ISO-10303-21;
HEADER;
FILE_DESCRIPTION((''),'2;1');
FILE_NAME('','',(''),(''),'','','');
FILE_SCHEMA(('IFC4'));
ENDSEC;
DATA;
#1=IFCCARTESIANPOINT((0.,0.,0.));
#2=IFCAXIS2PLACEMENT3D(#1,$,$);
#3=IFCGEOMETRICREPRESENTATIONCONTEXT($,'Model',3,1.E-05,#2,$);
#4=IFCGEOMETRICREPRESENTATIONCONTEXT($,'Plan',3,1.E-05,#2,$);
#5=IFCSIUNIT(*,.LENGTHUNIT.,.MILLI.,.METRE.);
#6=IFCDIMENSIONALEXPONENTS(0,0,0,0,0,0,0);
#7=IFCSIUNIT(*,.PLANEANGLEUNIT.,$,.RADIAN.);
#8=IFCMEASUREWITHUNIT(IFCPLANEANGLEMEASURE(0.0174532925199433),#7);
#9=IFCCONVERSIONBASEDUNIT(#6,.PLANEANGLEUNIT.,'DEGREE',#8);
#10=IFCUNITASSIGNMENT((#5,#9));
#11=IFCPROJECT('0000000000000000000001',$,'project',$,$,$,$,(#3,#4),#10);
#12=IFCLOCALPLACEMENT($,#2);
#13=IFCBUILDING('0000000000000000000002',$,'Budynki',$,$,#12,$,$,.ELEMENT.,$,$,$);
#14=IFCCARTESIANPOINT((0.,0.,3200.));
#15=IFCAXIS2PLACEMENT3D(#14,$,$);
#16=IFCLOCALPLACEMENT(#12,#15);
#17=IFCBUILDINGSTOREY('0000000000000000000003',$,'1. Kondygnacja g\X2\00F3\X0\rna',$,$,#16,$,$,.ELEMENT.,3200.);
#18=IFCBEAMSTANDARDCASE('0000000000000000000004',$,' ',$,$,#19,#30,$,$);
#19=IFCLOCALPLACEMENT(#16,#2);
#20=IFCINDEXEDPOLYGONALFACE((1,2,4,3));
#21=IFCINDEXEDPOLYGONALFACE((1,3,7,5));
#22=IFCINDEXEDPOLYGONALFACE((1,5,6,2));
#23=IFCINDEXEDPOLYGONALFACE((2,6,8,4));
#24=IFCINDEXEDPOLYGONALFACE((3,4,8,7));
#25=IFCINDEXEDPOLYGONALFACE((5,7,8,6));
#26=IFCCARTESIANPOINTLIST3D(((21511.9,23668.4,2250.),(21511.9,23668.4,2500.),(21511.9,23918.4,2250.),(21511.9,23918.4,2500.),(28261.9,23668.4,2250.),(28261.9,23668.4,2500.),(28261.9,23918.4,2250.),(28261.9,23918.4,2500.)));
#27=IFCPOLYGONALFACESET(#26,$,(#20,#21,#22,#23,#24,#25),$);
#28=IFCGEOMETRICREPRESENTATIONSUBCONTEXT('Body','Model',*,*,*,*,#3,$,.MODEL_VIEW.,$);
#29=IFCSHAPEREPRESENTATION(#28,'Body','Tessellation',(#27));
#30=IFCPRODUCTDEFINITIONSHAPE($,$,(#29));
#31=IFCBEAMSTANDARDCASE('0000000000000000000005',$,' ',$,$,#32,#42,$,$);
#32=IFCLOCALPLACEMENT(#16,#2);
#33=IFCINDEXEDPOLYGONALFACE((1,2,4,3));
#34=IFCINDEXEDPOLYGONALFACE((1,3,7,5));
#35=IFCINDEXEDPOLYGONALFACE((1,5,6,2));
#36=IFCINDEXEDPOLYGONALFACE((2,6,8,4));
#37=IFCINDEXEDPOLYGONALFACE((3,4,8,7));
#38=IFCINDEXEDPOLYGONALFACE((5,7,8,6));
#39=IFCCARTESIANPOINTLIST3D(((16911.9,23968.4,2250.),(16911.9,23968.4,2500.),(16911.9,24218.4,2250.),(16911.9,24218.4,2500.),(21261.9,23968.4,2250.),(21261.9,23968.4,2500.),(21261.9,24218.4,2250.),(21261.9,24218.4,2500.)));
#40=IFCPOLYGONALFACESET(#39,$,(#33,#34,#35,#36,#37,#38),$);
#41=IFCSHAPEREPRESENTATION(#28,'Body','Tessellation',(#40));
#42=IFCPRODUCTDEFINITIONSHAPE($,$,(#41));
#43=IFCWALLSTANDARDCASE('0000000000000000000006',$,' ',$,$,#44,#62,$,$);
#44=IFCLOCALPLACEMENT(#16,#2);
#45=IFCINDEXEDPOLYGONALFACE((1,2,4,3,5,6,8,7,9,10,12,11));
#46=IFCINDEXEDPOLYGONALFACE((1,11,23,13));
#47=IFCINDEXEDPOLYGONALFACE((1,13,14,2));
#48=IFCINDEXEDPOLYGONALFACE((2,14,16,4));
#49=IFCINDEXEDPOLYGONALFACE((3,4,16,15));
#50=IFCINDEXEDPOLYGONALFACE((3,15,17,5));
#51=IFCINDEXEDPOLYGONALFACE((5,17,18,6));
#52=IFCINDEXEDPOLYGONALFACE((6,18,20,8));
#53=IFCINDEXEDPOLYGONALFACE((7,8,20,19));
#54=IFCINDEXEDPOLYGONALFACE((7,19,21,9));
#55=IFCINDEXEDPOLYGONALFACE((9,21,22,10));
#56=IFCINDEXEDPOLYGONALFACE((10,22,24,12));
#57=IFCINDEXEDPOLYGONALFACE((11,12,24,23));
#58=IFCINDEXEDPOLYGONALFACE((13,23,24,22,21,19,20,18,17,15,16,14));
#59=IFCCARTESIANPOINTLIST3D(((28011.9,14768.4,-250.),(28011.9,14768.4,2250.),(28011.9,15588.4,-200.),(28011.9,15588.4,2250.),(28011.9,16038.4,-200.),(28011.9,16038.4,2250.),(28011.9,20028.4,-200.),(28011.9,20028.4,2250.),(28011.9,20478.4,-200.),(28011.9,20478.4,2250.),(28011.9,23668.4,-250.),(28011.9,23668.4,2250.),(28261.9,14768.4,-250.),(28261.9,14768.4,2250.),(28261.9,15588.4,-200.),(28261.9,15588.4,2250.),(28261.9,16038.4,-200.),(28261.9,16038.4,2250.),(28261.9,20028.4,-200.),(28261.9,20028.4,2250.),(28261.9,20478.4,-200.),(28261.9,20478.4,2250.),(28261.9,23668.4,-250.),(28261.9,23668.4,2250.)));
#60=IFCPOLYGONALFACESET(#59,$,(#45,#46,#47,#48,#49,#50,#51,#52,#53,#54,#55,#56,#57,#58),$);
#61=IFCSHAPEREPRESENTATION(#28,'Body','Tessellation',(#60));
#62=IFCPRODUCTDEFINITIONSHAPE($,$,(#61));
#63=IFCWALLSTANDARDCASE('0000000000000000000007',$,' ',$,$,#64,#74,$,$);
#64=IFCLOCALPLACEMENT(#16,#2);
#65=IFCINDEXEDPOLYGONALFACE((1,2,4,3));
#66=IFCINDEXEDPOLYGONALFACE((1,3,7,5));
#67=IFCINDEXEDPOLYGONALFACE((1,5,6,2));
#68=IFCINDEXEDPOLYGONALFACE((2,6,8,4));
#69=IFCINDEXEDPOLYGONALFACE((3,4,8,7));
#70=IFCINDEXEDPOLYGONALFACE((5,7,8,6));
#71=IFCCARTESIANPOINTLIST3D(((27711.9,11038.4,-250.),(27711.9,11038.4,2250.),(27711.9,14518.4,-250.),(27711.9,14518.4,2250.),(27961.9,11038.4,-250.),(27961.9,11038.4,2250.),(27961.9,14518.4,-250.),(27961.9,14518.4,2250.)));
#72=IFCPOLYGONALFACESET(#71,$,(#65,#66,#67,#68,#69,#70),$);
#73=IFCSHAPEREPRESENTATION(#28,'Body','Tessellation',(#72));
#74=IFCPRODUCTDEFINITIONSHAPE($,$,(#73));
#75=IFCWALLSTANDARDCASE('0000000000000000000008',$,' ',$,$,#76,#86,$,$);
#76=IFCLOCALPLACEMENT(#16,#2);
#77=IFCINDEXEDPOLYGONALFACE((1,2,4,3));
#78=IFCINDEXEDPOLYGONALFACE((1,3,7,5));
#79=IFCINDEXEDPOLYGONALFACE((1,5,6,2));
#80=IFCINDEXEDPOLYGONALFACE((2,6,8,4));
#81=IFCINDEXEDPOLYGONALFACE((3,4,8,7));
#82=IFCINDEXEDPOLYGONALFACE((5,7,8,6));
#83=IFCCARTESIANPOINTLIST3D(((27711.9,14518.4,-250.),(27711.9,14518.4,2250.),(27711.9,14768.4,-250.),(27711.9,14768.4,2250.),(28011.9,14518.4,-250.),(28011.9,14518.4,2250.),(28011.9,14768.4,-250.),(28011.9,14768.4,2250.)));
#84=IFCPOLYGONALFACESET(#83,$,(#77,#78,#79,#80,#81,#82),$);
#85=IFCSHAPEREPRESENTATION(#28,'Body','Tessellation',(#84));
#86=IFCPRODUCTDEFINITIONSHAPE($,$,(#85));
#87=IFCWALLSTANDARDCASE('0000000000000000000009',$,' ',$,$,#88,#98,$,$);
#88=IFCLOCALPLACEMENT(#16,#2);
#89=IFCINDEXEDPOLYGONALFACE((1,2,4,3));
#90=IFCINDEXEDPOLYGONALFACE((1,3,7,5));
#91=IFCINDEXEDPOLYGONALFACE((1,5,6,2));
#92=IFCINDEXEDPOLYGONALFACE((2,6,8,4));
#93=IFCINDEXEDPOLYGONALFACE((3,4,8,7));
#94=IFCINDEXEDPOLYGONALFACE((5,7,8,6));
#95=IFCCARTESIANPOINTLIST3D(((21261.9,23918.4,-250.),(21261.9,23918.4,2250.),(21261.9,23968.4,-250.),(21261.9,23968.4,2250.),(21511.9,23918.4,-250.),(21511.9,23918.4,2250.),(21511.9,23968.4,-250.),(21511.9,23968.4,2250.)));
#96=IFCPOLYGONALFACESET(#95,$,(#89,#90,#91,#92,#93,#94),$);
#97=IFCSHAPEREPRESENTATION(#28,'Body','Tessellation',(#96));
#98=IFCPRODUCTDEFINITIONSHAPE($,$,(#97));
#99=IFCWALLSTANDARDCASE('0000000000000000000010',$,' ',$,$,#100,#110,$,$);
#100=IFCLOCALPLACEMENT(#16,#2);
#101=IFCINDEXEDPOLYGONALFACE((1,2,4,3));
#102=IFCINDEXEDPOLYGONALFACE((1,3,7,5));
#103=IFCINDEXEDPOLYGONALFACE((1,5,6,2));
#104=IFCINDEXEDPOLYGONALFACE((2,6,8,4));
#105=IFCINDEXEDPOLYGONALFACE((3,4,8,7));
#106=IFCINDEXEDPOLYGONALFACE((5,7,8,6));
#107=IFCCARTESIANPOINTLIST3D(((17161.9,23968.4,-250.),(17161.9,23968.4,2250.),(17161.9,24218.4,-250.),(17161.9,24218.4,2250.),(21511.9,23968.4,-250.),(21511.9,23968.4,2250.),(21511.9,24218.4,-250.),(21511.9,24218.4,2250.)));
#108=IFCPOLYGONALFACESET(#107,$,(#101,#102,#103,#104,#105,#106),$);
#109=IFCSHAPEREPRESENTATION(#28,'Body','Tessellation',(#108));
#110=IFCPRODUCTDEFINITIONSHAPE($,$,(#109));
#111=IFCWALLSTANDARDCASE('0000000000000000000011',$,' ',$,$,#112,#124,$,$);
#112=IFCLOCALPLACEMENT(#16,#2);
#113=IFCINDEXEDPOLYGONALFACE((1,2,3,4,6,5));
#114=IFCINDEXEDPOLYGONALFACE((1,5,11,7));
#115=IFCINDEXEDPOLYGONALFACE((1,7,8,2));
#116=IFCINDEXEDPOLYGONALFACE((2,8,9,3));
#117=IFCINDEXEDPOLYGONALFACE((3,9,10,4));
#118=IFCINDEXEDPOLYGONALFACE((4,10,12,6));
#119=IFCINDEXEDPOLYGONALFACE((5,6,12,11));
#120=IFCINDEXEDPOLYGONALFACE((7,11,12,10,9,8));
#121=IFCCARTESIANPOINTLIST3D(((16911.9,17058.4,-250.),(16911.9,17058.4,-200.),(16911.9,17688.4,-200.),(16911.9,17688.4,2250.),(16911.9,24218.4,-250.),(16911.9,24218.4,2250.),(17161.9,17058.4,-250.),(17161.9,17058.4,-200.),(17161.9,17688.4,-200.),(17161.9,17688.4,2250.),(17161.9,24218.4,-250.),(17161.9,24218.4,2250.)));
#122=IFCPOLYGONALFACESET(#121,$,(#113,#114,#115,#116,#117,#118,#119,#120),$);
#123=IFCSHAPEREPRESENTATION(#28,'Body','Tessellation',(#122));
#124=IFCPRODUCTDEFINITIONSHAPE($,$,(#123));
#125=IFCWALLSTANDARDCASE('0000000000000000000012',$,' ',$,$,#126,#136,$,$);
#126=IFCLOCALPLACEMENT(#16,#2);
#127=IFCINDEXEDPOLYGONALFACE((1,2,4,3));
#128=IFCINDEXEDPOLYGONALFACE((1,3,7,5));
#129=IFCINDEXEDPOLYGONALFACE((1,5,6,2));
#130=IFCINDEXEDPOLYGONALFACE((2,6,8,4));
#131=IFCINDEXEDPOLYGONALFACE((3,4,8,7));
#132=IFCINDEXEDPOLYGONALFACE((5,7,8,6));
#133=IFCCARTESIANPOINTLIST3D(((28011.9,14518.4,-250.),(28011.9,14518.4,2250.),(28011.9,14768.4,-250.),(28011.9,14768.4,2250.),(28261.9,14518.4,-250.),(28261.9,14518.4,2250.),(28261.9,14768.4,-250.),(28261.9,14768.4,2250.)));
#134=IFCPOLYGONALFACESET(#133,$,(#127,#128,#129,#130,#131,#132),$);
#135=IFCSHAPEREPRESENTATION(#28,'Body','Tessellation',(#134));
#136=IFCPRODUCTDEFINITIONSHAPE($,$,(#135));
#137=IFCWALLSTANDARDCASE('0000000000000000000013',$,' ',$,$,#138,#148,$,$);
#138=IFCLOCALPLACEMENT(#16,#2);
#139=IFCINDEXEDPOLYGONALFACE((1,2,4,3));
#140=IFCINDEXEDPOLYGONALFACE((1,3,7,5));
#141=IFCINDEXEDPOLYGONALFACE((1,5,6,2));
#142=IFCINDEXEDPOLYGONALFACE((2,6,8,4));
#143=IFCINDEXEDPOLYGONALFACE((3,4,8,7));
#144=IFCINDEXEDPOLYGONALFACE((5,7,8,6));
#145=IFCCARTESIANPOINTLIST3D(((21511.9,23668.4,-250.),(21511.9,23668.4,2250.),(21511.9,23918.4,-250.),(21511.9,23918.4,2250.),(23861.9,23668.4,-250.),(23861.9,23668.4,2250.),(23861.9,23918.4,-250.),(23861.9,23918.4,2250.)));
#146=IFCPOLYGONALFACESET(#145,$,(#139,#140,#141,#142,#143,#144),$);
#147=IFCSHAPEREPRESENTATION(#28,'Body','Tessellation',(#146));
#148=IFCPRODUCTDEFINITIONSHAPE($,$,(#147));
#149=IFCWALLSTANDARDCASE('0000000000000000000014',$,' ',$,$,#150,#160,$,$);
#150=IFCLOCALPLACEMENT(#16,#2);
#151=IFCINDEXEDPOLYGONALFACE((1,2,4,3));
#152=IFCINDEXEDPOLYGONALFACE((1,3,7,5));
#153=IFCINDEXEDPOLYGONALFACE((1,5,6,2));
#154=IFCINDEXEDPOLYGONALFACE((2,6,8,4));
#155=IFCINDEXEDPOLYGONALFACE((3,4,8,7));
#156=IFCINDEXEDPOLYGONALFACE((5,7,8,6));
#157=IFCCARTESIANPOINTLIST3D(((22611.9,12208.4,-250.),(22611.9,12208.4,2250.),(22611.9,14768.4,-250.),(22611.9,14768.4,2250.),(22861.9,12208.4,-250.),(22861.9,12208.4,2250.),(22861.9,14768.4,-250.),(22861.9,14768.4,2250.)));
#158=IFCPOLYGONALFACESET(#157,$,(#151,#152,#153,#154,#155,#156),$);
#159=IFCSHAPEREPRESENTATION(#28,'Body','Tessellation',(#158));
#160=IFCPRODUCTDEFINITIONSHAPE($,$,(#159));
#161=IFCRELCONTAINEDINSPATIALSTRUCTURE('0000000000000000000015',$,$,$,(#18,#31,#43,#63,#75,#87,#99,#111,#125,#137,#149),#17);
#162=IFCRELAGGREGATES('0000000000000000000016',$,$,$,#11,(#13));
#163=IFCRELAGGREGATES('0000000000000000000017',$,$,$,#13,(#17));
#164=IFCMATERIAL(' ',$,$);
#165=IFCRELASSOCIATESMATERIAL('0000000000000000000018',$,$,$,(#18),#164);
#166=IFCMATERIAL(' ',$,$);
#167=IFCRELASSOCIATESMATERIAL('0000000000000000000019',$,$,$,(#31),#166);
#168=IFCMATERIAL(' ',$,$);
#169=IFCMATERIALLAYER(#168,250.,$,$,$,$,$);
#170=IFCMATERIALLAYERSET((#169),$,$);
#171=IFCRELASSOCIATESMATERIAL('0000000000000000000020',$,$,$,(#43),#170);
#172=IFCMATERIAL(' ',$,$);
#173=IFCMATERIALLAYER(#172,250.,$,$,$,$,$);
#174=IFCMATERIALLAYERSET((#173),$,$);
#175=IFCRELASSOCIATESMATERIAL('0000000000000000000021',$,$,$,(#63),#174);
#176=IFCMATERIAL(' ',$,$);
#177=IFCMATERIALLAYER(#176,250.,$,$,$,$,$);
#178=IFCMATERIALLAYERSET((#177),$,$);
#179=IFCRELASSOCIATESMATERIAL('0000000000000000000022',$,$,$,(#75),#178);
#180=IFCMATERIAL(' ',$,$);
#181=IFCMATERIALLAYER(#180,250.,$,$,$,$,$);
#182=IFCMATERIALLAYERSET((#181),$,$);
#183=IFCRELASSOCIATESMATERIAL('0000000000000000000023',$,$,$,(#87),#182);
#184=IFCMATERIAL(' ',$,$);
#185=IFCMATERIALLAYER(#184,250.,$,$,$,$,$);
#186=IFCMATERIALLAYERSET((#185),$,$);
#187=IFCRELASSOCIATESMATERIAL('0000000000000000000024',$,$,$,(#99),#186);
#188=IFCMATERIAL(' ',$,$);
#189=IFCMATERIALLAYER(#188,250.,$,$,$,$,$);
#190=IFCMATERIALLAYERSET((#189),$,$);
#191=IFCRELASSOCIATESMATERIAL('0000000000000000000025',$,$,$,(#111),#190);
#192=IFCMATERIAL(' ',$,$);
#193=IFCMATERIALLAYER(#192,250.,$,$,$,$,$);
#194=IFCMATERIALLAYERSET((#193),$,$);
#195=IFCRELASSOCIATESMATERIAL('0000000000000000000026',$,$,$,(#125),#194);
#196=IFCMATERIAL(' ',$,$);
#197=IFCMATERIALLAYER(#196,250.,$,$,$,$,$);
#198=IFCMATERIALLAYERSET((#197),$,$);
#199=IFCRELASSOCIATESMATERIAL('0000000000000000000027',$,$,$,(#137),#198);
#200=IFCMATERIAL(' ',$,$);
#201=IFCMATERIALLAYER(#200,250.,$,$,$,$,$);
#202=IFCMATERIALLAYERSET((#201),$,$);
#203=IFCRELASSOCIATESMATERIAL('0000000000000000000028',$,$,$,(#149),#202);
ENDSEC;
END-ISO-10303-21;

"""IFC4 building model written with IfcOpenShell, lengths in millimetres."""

from ifc_helpers import new_model, entity, si_unit, converted_unit, frame, frame_2d, origin, origin_with_axes, place, context, subcontext, project, spatial, polyline, rectangle, extrude, clip, bounded_halfspace, material, layer, layer_set, layer_usage, material_profile, profile_set, profile_usage, element, save


model = new_model("IFC4")

# Units and contexts
model_context = context("Model", 3, precision=1e-05, world=origin())
plan_context = context("Plan", 3, precision=1e-05, world=origin())
body_context = subcontext(model_context, "Body", "Model", "MODEL_VIEW")
ifc_project = project(units=[si_unit("LENGTHUNIT", "METRE", prefix="MILLI"), converted_unit("PLANEANGLEUNIT", "DEGREE", entity("IfcPlaneAngleMeasure", 0.0174532925199433), si_unit("PLANEANGLEUNIT", "RADIAN"), dimensions=[0, 0, 0, 0, 0, 0, 0])], contexts=[model_context, plan_context])

# Building, storey
building_placement = place(None, origin())
building = spatial("IfcBuilding", under=ifc_project, at=building_placement, Name="Budynki", CompositionType="ELEMENT")
storey_placement = place(building_placement, frame((0.0, 0.0, 3200.0)))
storey = spatial("IfcBuildingStorey", under=building, at=storey_placement, Name="1. Kondygnacja górna", CompositionType="ELEMENT", Elevation=3200.0)

# Beams
ifc_material_1 = material(Name=" ")
ifc_material_profile_1 = material_profile(ifc_material_1, rectangle(XDim=250.0, YDim=250.0, at=frame_2d((125.0, -125.0), x_axis=(0.0, 1.0))))
ifc_profile_set_1 = profile_set([ifc_material_profile_1])
ifc_profile_usage_1 = profile_usage(ifc_profile_set_1)
beam_1_placement = place(storey_placement, frame((28261.9, 23918.4, 2250.0), z_axis=(0.0, 0.0, 1.0), x_axis=(-1.0, 0.0, 0.0)))
element("IfcBeamStandardCase", 1, at=beam_1_placement, inside=storey, material=ifc_profile_usage_1, Name=" ", context=body_context, shape_type="SweptSolid", body=[
    extrude(rectangle(XDim=250.0, YDim=250.0, at=frame_2d((125.0, -125.0), x_axis=(0.0, 1.0))), frame((0.0, 0.0, 0.0), z_axis=(1.0, 0.0, 0.0), x_axis=(0.0, 0.0, 1.0)), (0.0, 0.0, 1.0), 6750.0),
])
ifc_material_2 = material(Name=" ")
ifc_material_profile_2 = material_profile(ifc_material_2, rectangle(XDim=250.0, YDim=250.0, at=frame_2d((125.0, -125.0), x_axis=(0.0, 1.0))))
ifc_profile_set_2 = profile_set([ifc_material_profile_2])
ifc_profile_usage_2 = profile_usage(ifc_profile_set_2)
beam_2_placement = place(storey_placement, frame((21261.9, 24218.4, 2250.0), z_axis=(0.0, 0.0, 1.0), x_axis=(-1.0, 0.0, 0.0)))
element("IfcBeamStandardCase", 2, at=beam_2_placement, inside=storey, material=ifc_profile_usage_2, Name=" ", context=body_context, shape_type="SweptSolid", body=[
    extrude(rectangle(XDim=250.0, YDim=250.0, at=frame_2d((125.0, -125.0), x_axis=(0.0, 1.0))), frame((0.0, 0.0, 0.0), z_axis=(1.0, 0.0, 0.0), x_axis=(0.0, 0.0, 1.0)), (0.0, 0.0, 1.0), 4350.0),
])

# Walls
ifc_material_3 = material(Name=" ")
ifc_layer_1 = layer(ifc_material_3, 250.0)
ifc_layer_set_1 = layer_set([ifc_layer_1])
ifc_layer_usage_1 = layer_usage(ifc_layer_set_1, "AXIS2", "POSITIVE", 0.0)
wall_1_placement = place(storey_placement, frame((28011.9, 23668.4, -250.0), z_axis=(0.0, 0.0, 1.0), x_axis=(0.0, -1.0, 0.0)))
element("IfcWallStandardCase", 3, at=wall_1_placement, inside=storey, material=ifc_layer_usage_1, Name=" ", context=body_context, shape_type="Clipping", body=[
    clip(clip(extrude(rectangle(XDim=8900.0, YDim=250.0, at=frame_2d((4450.0, 125.0), x_axis=(1.0, 0.0))), origin_with_axes(), (0.0, 0.0, 1.0), 2500.0), bounded_halfspace(frame((3415.0, 125.0, 50.0), z_axis=(0.0, 0.0, -1.0), x_axis=(0.0, 1.0, 0.0)), True, origin_with_axes(), polyline([(3640.0, 0.0), (3640.0, 250.0), (3190.0, 250.0), (3190.0, 0.0), (3640.0, 0.0)]))), bounded_halfspace(frame((7855.0, 125.0, 50.0), z_axis=(0.0, 0.0, -1.0), x_axis=(0.0, 1.0, 0.0)), True, origin_with_axes(), polyline([(8080.0, 0.0), (8080.0, 250.0), (7630.0, 250.0), (7630.0, 0.0), (8080.0, 0.0)]))),
])
ifc_material_4 = material(Name=" ")
ifc_layer_2 = layer(ifc_material_4, 250.0)
ifc_layer_set_2 = layer_set([ifc_layer_2])
ifc_layer_usage_2 = layer_usage(ifc_layer_set_2, "AXIS2", "POSITIVE", 0.0)
wall_2_placement = place(storey_placement, frame((27711.9, 14518.4, -250.0), z_axis=(0.0, 0.0, 1.0), x_axis=(0.0, -1.0, 0.0)))
element("IfcWallStandardCase", 4, at=wall_2_placement, inside=storey, material=ifc_layer_usage_2, Name=" ", context=body_context, shape_type="SweptSolid", body=[
    extrude(rectangle(XDim=3480.0, YDim=250.0, at=frame_2d((1740.0, 125.0), x_axis=(1.0, 0.0))), origin_with_axes(), (0.0, 0.0, 1.0), 2500.0),
])
ifc_material_5 = material(Name=" ")
ifc_layer_3 = layer(ifc_material_5, 250.0)
ifc_layer_set_3 = layer_set([ifc_layer_3])
ifc_layer_usage_3 = layer_usage(ifc_layer_set_3, "AXIS2", "POSITIVE", 0.0)
wall_3_placement = place(storey_placement, frame((28011.9, 14768.4, -250.0), z_axis=(0.0, 0.0, 1.0), x_axis=(-1.0, 0.0, 0.0)))
element("IfcWallStandardCase", 5, at=wall_3_placement, inside=storey, material=ifc_layer_usage_3, Name=" ", context=body_context, shape_type="SweptSolid", body=[
    extrude(rectangle(XDim=300.0, YDim=250.0, at=frame_2d((150.0, 125.0), x_axis=(1.0, 0.0))), origin_with_axes(), (0.0, 0.0, 1.0), 2500.0),
])
ifc_material_6 = material(Name=" ")
ifc_layer_4 = layer(ifc_material_6, 250.0)
ifc_layer_set_4 = layer_set([ifc_layer_4])
ifc_layer_usage_4 = layer_usage(ifc_layer_set_4, "AXIS2", "POSITIVE", 0.0)
wall_4_placement = place(storey_placement, frame((21511.9, 23918.4, -250.0), z_axis=(0.0, 0.0, 1.0), x_axis=(0.0, 1.0, 0.0)))
element("IfcWallStandardCase", 6, at=wall_4_placement, inside=storey, material=ifc_layer_usage_4, Name=" ", context=body_context, shape_type="SweptSolid", body=[
    extrude(rectangle(XDim=50.0, YDim=250.0, at=frame_2d((25.0, 125.0), x_axis=(1.0, 0.0))), origin_with_axes(), (0.0, 0.0, 1.0), 2500.0),
])
ifc_material_7 = material(Name=" ")
ifc_layer_5 = layer(ifc_material_7, 250.0)
ifc_layer_set_5 = layer_set([ifc_layer_5])
ifc_layer_usage_5 = layer_usage(ifc_layer_set_5, "AXIS2", "POSITIVE", 0.0)
wall_5_placement = place(storey_placement, frame((21511.9, 24218.4, -250.0), z_axis=(0.0, 0.0, 1.0), x_axis=(-1.0, 0.0, 0.0)))
element("IfcWallStandardCase", 7, at=wall_5_placement, inside=storey, material=ifc_layer_usage_5, Name=" ", context=body_context, shape_type="SweptSolid", body=[
    extrude(rectangle(XDim=4350.0, YDim=250.0, at=frame_2d((2175.0, 125.0), x_axis=(1.0, 0.0))), origin_with_axes(), (0.0, 0.0, 1.0), 2500.0),
])
ifc_material_8 = material(Name=" ")
ifc_layer_6 = layer(ifc_material_8, 250.0)
ifc_layer_set_6 = layer_set([ifc_layer_6])
ifc_layer_usage_6 = layer_usage(ifc_layer_set_6, "AXIS2", "POSITIVE", 0.0)
wall_6_placement = place(storey_placement, frame((16911.9, 24218.4, -250.0), z_axis=(0.0, 0.0, 1.0), x_axis=(0.0, -1.0, 0.0)))
element("IfcWallStandardCase", 8, at=wall_6_placement, inside=storey, material=ifc_layer_usage_6, Name=" ", context=body_context, shape_type="Clipping", body=[
    clip(extrude(rectangle(XDim=7160.0, YDim=250.0, at=frame_2d((3580.0, 125.0), x_axis=(1.0, 0.0))), origin_with_axes(), (0.0, 0.0, 1.0), 2500.0), bounded_halfspace(frame((6845.0, 125.0, 50.0), z_axis=(0.0, 0.0, -1.0), x_axis=(0.0, 1.0, 0.0)), True, origin_with_axes(), polyline([(7160.0, 0.0), (7160.0, 250.0), (6530.0, 250.0), (6530.0, 0.0), (7160.0, 0.0)]))),
])
ifc_material_9 = material(Name=" ")
ifc_layer_7 = layer(ifc_material_9, 250.0)
ifc_layer_set_7 = layer_set([ifc_layer_7])
ifc_layer_usage_7 = layer_usage(ifc_layer_set_7, "AXIS2", "POSITIVE", 0.0)
wall_7_placement = place(storey_placement, frame((28261.9, 14768.4, -250.0), z_axis=(0.0, 0.0, 1.0), x_axis=(-1.0, 0.0, 0.0)))
element("IfcWallStandardCase", 9, at=wall_7_placement, inside=storey, material=ifc_layer_usage_7, Name=" ", context=body_context, shape_type="SweptSolid", body=[
    extrude(rectangle(XDim=250.0, YDim=250.0, at=frame_2d((125.0, 125.0), x_axis=(1.0, 0.0))), origin_with_axes(), (0.0, 0.0, 1.0), 2500.0),
])
ifc_material_10 = material(Name=" ")
ifc_layer_8 = layer(ifc_material_10, 250.0)
ifc_layer_set_8 = layer_set([ifc_layer_8])
ifc_layer_usage_8 = layer_usage(ifc_layer_set_8, "AXIS2", "POSITIVE", 0.0)
wall_8_placement = place(storey_placement, frame((21511.9, 23668.4, -250.0)))
element("IfcWallStandardCase", 10, at=wall_8_placement, inside=storey, material=ifc_layer_usage_8, Name=" ", context=body_context, shape_type="SweptSolid", body=[
    extrude(rectangle(XDim=2350.0, YDim=250.0, at=frame_2d((1175.0, 125.0), x_axis=(1.0, 0.0))), origin_with_axes(), (0.0, 0.0, 1.0), 2500.0),
])
ifc_material_11 = material(Name=" ")
ifc_layer_9 = layer(ifc_material_11, 250.0)
ifc_layer_set_9 = layer_set([ifc_layer_9])
ifc_layer_usage_9 = layer_usage(ifc_layer_set_9, "AXIS2", "POSITIVE", 0.0)
wall_9_placement = place(storey_placement, frame((22611.9, 14768.4, -250.0), z_axis=(0.0, 0.0, 1.0), x_axis=(0.0, -1.0, 0.0)))
element("IfcWallStandardCase", 11, at=wall_9_placement, inside=storey, material=ifc_layer_usage_9, Name=" ", context=body_context, shape_type="SweptSolid", body=[
    extrude(rectangle(XDim=2560.0, YDim=250.0, at=frame_2d((1280.0, 125.0), x_axis=(1.0, 0.0))), origin_with_axes(), (0.0, 0.0, 1.0), 2500.0),
])

save(model, "model.ifc")
